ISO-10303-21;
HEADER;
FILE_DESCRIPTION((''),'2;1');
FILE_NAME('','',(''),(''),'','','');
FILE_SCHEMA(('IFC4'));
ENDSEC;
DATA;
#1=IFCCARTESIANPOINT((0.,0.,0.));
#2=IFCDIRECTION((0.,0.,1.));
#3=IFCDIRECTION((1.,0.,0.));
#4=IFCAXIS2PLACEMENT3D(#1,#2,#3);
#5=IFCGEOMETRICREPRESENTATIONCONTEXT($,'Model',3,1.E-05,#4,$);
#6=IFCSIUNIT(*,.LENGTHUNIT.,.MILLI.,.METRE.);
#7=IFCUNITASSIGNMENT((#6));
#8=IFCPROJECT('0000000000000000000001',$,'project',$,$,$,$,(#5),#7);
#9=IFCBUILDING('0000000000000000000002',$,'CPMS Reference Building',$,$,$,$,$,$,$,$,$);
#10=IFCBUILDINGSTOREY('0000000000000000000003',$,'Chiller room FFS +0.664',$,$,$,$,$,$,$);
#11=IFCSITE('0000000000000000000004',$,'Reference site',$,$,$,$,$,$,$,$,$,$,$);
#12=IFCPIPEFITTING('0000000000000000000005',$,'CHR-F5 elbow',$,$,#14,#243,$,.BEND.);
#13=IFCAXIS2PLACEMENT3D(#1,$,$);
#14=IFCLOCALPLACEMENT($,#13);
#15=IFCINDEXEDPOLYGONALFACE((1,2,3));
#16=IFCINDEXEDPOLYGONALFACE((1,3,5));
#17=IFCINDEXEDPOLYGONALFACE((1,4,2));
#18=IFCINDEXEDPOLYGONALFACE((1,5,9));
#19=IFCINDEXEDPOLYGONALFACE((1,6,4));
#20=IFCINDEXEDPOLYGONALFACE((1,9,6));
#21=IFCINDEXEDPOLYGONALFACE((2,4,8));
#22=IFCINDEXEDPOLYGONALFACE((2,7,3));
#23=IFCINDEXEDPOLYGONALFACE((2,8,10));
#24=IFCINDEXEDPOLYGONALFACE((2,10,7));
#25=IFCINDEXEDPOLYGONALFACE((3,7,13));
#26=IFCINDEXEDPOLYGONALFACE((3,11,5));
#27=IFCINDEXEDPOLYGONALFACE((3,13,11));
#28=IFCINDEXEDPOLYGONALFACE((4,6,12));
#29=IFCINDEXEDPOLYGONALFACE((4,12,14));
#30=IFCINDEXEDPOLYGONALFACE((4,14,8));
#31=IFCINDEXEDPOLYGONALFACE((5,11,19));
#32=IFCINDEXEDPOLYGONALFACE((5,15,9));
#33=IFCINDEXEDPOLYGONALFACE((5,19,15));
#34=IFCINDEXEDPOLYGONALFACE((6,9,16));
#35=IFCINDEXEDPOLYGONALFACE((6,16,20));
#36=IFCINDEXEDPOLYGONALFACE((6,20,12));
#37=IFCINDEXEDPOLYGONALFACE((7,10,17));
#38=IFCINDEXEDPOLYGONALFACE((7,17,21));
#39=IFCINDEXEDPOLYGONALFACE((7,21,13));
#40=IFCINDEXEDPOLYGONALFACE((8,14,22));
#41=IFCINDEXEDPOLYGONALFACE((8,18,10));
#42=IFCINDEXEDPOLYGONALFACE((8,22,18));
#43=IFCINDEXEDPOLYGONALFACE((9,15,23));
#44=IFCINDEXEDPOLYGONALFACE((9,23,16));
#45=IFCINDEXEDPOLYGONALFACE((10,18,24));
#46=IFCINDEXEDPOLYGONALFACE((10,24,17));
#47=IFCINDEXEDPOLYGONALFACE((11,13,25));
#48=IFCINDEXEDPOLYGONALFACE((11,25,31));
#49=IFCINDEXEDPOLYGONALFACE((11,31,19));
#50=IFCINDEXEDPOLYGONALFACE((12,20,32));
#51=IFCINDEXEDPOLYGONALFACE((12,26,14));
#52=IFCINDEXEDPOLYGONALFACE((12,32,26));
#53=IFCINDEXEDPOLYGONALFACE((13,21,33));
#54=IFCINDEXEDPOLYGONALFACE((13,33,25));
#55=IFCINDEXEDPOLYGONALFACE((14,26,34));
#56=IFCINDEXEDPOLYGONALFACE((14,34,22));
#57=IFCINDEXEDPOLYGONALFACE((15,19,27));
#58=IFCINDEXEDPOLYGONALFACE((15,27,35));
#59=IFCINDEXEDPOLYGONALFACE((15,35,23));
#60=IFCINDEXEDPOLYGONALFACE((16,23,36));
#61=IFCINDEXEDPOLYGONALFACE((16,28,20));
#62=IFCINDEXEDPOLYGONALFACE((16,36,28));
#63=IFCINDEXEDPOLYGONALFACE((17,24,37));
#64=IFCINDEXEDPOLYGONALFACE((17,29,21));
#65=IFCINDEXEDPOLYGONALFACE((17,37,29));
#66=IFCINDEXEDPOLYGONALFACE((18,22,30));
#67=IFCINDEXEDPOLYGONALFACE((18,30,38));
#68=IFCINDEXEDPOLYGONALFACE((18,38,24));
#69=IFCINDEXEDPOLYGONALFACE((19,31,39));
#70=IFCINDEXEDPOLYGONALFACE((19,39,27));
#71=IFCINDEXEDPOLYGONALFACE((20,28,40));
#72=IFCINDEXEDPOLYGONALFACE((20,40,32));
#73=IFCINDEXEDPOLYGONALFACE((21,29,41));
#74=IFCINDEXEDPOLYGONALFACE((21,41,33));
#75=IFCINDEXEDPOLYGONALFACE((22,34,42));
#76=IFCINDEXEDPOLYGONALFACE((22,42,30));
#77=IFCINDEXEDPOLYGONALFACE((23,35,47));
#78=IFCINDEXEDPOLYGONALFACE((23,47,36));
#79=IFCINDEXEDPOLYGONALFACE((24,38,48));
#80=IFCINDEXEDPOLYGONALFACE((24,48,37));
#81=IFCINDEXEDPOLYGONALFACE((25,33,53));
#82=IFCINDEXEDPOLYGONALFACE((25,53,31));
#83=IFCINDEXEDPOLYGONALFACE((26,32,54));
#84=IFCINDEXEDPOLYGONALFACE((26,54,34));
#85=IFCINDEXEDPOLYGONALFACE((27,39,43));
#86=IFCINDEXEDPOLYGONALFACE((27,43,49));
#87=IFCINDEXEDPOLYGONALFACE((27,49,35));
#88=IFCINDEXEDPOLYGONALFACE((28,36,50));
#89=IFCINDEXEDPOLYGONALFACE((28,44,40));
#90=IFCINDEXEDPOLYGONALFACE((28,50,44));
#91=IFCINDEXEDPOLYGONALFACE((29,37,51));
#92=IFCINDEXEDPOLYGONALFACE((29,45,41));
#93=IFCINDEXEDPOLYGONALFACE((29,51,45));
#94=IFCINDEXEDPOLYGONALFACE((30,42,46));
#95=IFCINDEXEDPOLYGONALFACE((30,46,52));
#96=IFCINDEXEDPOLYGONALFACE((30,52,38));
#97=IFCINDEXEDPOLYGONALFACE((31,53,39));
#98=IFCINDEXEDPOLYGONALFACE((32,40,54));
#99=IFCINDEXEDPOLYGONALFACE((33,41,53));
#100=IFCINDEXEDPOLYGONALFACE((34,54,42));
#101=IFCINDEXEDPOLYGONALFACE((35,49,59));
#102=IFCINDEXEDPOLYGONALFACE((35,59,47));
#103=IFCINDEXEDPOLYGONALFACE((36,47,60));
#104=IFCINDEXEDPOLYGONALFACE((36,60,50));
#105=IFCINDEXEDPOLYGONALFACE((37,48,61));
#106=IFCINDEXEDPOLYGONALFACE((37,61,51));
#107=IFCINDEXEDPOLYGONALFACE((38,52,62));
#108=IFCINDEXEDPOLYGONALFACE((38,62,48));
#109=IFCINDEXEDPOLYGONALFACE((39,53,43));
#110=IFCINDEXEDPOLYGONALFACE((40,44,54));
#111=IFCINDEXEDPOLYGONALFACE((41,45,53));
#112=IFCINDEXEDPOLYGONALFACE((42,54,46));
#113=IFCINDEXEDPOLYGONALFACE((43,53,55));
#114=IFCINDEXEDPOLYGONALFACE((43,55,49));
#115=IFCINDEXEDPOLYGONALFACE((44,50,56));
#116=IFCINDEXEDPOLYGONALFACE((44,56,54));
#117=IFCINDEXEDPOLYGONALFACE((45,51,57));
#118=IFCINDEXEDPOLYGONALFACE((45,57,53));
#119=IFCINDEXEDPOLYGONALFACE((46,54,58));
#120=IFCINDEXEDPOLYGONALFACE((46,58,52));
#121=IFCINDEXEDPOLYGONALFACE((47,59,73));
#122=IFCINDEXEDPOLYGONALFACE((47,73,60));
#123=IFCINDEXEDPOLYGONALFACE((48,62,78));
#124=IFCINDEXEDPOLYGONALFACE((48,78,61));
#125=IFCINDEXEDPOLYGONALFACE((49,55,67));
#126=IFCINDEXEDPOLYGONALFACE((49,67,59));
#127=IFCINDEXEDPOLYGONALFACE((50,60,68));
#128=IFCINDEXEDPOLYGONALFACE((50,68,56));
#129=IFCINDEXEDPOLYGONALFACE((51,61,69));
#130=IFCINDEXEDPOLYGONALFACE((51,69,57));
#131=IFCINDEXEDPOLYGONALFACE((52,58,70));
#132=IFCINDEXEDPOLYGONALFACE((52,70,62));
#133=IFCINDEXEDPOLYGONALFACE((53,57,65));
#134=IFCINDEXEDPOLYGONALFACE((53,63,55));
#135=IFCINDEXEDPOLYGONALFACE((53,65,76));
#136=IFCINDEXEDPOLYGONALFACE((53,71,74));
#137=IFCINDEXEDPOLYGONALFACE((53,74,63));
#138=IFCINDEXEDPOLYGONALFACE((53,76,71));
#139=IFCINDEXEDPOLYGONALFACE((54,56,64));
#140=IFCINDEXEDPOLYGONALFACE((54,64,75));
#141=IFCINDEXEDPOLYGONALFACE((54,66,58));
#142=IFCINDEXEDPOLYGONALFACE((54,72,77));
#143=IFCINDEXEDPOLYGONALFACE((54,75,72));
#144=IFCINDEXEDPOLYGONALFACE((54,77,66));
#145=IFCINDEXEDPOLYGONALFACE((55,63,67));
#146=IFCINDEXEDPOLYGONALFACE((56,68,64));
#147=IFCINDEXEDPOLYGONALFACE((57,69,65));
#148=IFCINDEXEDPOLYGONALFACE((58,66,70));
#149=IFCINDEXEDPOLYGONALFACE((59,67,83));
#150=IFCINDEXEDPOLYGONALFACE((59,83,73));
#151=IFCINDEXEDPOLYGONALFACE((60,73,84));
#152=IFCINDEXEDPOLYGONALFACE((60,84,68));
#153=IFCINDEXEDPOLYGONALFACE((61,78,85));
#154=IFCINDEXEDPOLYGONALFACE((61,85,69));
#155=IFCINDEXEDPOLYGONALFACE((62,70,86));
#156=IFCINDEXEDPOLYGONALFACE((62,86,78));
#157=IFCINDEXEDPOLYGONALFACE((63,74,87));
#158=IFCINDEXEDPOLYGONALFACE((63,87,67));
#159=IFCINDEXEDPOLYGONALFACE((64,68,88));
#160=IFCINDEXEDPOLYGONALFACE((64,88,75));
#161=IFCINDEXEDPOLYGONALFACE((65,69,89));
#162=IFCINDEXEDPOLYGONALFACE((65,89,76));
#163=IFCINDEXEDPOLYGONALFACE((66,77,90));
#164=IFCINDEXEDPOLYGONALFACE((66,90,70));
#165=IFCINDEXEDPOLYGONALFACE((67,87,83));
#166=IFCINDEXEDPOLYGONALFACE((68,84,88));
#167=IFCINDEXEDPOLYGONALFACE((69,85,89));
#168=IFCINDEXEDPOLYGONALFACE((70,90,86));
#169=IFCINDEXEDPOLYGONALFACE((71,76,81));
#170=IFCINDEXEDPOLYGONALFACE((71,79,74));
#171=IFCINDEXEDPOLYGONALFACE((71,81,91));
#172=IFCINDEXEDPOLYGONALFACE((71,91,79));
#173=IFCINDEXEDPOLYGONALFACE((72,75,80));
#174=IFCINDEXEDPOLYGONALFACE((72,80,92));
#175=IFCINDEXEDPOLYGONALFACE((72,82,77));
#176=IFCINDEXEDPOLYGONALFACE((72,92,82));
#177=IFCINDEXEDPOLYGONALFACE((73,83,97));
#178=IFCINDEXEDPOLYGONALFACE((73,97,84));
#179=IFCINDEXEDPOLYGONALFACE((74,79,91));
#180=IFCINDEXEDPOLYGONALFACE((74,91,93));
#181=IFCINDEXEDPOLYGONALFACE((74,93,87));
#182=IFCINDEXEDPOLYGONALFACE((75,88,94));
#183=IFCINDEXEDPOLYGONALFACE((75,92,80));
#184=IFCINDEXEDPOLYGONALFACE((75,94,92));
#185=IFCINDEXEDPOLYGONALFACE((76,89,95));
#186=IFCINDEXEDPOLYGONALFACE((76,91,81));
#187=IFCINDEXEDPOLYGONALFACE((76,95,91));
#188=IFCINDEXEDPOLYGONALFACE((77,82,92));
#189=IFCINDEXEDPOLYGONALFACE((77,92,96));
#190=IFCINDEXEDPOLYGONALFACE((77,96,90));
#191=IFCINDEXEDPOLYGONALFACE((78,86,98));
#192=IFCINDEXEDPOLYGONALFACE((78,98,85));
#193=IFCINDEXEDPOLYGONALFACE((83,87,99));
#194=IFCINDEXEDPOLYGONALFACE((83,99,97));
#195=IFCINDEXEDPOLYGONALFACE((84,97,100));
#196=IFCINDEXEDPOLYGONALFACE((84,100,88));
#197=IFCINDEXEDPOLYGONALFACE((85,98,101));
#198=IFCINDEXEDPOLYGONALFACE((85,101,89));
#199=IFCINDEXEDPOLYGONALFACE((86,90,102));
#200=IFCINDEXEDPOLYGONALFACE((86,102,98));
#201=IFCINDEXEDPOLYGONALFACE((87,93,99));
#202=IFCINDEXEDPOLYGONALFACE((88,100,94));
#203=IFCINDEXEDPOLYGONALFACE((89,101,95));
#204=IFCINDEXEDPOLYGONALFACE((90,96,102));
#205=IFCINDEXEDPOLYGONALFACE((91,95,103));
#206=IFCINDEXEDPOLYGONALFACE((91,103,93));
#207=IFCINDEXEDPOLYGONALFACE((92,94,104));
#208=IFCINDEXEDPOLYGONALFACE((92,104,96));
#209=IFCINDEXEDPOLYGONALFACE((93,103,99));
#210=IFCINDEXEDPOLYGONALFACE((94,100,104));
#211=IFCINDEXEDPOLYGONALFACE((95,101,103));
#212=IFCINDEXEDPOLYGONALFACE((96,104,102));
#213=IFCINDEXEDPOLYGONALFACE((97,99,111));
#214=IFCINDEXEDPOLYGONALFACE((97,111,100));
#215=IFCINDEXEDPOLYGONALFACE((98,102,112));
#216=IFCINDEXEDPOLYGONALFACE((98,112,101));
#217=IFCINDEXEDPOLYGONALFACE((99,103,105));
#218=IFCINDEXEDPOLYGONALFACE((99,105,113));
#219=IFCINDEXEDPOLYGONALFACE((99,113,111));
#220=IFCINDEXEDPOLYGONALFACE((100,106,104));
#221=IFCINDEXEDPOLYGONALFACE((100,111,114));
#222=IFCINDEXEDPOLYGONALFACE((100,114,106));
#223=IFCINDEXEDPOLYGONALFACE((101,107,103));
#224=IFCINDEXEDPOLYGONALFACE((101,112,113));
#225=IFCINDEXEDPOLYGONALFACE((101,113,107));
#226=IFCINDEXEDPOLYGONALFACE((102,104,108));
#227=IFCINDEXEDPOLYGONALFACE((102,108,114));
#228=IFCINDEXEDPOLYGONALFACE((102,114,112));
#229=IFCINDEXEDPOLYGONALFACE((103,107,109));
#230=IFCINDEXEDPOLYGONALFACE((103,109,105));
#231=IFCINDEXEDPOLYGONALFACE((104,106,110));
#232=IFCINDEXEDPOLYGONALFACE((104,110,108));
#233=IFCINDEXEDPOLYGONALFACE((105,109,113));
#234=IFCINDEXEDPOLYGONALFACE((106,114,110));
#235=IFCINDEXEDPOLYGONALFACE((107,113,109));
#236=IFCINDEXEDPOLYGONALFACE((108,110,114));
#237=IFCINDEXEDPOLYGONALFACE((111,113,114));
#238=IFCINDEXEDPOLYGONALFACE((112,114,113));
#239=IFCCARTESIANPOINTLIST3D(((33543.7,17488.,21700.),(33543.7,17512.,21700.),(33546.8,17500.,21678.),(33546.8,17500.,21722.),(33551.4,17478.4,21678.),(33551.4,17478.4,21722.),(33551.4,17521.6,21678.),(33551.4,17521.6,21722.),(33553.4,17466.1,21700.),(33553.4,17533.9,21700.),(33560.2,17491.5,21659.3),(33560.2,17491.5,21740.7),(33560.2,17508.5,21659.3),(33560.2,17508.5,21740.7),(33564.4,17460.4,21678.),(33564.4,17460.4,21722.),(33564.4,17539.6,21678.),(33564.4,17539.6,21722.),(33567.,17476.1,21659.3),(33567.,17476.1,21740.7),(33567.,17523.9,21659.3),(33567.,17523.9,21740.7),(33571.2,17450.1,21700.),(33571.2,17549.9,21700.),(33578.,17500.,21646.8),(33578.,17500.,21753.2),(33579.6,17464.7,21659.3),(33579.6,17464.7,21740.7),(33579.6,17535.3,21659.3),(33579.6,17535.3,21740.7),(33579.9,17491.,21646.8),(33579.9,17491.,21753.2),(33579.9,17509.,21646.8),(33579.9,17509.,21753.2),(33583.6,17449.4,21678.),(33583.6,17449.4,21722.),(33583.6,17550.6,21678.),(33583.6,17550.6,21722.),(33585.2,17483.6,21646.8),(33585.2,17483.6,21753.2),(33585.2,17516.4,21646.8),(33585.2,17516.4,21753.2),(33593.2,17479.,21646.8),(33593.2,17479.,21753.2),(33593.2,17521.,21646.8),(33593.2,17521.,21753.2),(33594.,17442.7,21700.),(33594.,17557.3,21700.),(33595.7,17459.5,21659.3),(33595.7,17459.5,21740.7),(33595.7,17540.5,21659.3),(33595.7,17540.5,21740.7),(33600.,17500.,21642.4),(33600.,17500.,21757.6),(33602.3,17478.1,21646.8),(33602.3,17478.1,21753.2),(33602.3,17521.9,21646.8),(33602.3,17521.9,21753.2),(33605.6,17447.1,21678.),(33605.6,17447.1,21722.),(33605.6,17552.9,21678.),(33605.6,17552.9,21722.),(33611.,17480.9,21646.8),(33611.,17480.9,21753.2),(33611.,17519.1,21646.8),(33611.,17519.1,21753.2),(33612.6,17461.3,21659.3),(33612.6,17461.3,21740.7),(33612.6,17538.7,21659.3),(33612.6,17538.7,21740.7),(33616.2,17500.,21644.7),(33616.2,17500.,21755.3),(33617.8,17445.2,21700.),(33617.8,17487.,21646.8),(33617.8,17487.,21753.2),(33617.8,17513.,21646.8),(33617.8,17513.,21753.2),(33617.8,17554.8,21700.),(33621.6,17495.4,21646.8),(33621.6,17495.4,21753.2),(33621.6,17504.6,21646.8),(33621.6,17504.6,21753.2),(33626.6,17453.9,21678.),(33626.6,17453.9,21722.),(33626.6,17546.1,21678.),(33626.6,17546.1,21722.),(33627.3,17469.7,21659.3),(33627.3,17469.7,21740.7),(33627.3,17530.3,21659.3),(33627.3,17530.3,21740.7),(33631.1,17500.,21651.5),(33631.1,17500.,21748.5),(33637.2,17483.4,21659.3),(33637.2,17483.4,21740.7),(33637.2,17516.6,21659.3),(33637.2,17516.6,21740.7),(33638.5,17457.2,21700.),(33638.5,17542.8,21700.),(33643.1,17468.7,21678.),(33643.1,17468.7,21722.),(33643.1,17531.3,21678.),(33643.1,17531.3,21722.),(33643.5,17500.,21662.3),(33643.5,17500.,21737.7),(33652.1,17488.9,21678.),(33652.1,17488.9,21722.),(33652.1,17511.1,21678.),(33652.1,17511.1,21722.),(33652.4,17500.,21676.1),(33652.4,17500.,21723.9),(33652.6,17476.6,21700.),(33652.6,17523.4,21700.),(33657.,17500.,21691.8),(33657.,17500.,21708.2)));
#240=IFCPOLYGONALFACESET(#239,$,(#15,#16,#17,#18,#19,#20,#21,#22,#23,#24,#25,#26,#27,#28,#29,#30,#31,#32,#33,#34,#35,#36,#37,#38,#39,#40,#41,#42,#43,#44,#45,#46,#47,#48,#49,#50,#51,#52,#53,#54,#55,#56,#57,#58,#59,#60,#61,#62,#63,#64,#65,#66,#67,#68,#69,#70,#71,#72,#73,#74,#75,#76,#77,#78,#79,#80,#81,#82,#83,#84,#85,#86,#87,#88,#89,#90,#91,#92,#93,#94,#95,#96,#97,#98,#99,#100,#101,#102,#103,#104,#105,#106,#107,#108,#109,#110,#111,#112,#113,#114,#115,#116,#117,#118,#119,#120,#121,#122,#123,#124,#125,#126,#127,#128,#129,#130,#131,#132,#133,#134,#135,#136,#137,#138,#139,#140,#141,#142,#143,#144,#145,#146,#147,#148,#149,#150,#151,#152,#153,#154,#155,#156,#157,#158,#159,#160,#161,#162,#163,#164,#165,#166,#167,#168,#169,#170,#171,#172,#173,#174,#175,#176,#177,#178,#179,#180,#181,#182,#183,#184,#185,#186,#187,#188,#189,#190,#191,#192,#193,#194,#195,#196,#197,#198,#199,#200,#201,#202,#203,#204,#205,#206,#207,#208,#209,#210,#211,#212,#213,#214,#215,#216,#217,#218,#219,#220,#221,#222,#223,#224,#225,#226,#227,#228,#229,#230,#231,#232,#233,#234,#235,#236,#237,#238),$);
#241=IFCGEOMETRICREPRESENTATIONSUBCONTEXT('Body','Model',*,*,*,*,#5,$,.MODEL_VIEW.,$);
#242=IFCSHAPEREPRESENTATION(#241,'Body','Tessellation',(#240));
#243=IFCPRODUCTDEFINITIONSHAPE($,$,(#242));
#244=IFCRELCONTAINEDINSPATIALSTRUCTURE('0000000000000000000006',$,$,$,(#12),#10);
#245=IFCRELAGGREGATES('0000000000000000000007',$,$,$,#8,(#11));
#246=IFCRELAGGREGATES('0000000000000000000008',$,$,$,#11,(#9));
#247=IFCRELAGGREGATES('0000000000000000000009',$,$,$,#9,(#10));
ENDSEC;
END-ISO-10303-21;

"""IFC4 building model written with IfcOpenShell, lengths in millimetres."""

from ifc_helpers import new_model, entity, si_unit, origin_with_axes, place, context, subcontext, project, spatial, element, save


model = new_model("IFC4")

# Units and contexts
model_context = context("Model", 3, precision=1e-05, world=origin_with_axes())
body_context = subcontext(model_context, "Body", "Model", "MODEL_VIEW")
ifc_project = project(units=[si_unit("LENGTHUNIT", "METRE", prefix="MILLI")], contexts=[model_context])

# Site, building, storey
site = spatial("IfcSite", under=ifc_project, Name="Reference site")
building = spatial("IfcBuilding", under=site, Name="CPMS Reference Building")
storey = spatial("IfcBuildingStorey", under=building, Name="Chiller room FFS +0.664")

# Pipe fitting
pipe_fitting_1_placement = place(None, origin_with_axes())
element("IfcPipeFitting", 1, at=pipe_fitting_1_placement, inside=storey, Name="CHR-F5 elbow", PredefinedType="BEND", context=body_context, shape_type="CSG", body=[
    entity("IfcSphere", entity("IfcAxis2Placement3D", entity("IfcCartesianPoint", [33600.0, 17500.0, 21700.0]), entity("IfcDirection", [0.0, 0.0, 1.0]), entity("IfcDirection", [1.0, 0.0, 0.0])), 57.6),
])

save(model, "model.ifc")
